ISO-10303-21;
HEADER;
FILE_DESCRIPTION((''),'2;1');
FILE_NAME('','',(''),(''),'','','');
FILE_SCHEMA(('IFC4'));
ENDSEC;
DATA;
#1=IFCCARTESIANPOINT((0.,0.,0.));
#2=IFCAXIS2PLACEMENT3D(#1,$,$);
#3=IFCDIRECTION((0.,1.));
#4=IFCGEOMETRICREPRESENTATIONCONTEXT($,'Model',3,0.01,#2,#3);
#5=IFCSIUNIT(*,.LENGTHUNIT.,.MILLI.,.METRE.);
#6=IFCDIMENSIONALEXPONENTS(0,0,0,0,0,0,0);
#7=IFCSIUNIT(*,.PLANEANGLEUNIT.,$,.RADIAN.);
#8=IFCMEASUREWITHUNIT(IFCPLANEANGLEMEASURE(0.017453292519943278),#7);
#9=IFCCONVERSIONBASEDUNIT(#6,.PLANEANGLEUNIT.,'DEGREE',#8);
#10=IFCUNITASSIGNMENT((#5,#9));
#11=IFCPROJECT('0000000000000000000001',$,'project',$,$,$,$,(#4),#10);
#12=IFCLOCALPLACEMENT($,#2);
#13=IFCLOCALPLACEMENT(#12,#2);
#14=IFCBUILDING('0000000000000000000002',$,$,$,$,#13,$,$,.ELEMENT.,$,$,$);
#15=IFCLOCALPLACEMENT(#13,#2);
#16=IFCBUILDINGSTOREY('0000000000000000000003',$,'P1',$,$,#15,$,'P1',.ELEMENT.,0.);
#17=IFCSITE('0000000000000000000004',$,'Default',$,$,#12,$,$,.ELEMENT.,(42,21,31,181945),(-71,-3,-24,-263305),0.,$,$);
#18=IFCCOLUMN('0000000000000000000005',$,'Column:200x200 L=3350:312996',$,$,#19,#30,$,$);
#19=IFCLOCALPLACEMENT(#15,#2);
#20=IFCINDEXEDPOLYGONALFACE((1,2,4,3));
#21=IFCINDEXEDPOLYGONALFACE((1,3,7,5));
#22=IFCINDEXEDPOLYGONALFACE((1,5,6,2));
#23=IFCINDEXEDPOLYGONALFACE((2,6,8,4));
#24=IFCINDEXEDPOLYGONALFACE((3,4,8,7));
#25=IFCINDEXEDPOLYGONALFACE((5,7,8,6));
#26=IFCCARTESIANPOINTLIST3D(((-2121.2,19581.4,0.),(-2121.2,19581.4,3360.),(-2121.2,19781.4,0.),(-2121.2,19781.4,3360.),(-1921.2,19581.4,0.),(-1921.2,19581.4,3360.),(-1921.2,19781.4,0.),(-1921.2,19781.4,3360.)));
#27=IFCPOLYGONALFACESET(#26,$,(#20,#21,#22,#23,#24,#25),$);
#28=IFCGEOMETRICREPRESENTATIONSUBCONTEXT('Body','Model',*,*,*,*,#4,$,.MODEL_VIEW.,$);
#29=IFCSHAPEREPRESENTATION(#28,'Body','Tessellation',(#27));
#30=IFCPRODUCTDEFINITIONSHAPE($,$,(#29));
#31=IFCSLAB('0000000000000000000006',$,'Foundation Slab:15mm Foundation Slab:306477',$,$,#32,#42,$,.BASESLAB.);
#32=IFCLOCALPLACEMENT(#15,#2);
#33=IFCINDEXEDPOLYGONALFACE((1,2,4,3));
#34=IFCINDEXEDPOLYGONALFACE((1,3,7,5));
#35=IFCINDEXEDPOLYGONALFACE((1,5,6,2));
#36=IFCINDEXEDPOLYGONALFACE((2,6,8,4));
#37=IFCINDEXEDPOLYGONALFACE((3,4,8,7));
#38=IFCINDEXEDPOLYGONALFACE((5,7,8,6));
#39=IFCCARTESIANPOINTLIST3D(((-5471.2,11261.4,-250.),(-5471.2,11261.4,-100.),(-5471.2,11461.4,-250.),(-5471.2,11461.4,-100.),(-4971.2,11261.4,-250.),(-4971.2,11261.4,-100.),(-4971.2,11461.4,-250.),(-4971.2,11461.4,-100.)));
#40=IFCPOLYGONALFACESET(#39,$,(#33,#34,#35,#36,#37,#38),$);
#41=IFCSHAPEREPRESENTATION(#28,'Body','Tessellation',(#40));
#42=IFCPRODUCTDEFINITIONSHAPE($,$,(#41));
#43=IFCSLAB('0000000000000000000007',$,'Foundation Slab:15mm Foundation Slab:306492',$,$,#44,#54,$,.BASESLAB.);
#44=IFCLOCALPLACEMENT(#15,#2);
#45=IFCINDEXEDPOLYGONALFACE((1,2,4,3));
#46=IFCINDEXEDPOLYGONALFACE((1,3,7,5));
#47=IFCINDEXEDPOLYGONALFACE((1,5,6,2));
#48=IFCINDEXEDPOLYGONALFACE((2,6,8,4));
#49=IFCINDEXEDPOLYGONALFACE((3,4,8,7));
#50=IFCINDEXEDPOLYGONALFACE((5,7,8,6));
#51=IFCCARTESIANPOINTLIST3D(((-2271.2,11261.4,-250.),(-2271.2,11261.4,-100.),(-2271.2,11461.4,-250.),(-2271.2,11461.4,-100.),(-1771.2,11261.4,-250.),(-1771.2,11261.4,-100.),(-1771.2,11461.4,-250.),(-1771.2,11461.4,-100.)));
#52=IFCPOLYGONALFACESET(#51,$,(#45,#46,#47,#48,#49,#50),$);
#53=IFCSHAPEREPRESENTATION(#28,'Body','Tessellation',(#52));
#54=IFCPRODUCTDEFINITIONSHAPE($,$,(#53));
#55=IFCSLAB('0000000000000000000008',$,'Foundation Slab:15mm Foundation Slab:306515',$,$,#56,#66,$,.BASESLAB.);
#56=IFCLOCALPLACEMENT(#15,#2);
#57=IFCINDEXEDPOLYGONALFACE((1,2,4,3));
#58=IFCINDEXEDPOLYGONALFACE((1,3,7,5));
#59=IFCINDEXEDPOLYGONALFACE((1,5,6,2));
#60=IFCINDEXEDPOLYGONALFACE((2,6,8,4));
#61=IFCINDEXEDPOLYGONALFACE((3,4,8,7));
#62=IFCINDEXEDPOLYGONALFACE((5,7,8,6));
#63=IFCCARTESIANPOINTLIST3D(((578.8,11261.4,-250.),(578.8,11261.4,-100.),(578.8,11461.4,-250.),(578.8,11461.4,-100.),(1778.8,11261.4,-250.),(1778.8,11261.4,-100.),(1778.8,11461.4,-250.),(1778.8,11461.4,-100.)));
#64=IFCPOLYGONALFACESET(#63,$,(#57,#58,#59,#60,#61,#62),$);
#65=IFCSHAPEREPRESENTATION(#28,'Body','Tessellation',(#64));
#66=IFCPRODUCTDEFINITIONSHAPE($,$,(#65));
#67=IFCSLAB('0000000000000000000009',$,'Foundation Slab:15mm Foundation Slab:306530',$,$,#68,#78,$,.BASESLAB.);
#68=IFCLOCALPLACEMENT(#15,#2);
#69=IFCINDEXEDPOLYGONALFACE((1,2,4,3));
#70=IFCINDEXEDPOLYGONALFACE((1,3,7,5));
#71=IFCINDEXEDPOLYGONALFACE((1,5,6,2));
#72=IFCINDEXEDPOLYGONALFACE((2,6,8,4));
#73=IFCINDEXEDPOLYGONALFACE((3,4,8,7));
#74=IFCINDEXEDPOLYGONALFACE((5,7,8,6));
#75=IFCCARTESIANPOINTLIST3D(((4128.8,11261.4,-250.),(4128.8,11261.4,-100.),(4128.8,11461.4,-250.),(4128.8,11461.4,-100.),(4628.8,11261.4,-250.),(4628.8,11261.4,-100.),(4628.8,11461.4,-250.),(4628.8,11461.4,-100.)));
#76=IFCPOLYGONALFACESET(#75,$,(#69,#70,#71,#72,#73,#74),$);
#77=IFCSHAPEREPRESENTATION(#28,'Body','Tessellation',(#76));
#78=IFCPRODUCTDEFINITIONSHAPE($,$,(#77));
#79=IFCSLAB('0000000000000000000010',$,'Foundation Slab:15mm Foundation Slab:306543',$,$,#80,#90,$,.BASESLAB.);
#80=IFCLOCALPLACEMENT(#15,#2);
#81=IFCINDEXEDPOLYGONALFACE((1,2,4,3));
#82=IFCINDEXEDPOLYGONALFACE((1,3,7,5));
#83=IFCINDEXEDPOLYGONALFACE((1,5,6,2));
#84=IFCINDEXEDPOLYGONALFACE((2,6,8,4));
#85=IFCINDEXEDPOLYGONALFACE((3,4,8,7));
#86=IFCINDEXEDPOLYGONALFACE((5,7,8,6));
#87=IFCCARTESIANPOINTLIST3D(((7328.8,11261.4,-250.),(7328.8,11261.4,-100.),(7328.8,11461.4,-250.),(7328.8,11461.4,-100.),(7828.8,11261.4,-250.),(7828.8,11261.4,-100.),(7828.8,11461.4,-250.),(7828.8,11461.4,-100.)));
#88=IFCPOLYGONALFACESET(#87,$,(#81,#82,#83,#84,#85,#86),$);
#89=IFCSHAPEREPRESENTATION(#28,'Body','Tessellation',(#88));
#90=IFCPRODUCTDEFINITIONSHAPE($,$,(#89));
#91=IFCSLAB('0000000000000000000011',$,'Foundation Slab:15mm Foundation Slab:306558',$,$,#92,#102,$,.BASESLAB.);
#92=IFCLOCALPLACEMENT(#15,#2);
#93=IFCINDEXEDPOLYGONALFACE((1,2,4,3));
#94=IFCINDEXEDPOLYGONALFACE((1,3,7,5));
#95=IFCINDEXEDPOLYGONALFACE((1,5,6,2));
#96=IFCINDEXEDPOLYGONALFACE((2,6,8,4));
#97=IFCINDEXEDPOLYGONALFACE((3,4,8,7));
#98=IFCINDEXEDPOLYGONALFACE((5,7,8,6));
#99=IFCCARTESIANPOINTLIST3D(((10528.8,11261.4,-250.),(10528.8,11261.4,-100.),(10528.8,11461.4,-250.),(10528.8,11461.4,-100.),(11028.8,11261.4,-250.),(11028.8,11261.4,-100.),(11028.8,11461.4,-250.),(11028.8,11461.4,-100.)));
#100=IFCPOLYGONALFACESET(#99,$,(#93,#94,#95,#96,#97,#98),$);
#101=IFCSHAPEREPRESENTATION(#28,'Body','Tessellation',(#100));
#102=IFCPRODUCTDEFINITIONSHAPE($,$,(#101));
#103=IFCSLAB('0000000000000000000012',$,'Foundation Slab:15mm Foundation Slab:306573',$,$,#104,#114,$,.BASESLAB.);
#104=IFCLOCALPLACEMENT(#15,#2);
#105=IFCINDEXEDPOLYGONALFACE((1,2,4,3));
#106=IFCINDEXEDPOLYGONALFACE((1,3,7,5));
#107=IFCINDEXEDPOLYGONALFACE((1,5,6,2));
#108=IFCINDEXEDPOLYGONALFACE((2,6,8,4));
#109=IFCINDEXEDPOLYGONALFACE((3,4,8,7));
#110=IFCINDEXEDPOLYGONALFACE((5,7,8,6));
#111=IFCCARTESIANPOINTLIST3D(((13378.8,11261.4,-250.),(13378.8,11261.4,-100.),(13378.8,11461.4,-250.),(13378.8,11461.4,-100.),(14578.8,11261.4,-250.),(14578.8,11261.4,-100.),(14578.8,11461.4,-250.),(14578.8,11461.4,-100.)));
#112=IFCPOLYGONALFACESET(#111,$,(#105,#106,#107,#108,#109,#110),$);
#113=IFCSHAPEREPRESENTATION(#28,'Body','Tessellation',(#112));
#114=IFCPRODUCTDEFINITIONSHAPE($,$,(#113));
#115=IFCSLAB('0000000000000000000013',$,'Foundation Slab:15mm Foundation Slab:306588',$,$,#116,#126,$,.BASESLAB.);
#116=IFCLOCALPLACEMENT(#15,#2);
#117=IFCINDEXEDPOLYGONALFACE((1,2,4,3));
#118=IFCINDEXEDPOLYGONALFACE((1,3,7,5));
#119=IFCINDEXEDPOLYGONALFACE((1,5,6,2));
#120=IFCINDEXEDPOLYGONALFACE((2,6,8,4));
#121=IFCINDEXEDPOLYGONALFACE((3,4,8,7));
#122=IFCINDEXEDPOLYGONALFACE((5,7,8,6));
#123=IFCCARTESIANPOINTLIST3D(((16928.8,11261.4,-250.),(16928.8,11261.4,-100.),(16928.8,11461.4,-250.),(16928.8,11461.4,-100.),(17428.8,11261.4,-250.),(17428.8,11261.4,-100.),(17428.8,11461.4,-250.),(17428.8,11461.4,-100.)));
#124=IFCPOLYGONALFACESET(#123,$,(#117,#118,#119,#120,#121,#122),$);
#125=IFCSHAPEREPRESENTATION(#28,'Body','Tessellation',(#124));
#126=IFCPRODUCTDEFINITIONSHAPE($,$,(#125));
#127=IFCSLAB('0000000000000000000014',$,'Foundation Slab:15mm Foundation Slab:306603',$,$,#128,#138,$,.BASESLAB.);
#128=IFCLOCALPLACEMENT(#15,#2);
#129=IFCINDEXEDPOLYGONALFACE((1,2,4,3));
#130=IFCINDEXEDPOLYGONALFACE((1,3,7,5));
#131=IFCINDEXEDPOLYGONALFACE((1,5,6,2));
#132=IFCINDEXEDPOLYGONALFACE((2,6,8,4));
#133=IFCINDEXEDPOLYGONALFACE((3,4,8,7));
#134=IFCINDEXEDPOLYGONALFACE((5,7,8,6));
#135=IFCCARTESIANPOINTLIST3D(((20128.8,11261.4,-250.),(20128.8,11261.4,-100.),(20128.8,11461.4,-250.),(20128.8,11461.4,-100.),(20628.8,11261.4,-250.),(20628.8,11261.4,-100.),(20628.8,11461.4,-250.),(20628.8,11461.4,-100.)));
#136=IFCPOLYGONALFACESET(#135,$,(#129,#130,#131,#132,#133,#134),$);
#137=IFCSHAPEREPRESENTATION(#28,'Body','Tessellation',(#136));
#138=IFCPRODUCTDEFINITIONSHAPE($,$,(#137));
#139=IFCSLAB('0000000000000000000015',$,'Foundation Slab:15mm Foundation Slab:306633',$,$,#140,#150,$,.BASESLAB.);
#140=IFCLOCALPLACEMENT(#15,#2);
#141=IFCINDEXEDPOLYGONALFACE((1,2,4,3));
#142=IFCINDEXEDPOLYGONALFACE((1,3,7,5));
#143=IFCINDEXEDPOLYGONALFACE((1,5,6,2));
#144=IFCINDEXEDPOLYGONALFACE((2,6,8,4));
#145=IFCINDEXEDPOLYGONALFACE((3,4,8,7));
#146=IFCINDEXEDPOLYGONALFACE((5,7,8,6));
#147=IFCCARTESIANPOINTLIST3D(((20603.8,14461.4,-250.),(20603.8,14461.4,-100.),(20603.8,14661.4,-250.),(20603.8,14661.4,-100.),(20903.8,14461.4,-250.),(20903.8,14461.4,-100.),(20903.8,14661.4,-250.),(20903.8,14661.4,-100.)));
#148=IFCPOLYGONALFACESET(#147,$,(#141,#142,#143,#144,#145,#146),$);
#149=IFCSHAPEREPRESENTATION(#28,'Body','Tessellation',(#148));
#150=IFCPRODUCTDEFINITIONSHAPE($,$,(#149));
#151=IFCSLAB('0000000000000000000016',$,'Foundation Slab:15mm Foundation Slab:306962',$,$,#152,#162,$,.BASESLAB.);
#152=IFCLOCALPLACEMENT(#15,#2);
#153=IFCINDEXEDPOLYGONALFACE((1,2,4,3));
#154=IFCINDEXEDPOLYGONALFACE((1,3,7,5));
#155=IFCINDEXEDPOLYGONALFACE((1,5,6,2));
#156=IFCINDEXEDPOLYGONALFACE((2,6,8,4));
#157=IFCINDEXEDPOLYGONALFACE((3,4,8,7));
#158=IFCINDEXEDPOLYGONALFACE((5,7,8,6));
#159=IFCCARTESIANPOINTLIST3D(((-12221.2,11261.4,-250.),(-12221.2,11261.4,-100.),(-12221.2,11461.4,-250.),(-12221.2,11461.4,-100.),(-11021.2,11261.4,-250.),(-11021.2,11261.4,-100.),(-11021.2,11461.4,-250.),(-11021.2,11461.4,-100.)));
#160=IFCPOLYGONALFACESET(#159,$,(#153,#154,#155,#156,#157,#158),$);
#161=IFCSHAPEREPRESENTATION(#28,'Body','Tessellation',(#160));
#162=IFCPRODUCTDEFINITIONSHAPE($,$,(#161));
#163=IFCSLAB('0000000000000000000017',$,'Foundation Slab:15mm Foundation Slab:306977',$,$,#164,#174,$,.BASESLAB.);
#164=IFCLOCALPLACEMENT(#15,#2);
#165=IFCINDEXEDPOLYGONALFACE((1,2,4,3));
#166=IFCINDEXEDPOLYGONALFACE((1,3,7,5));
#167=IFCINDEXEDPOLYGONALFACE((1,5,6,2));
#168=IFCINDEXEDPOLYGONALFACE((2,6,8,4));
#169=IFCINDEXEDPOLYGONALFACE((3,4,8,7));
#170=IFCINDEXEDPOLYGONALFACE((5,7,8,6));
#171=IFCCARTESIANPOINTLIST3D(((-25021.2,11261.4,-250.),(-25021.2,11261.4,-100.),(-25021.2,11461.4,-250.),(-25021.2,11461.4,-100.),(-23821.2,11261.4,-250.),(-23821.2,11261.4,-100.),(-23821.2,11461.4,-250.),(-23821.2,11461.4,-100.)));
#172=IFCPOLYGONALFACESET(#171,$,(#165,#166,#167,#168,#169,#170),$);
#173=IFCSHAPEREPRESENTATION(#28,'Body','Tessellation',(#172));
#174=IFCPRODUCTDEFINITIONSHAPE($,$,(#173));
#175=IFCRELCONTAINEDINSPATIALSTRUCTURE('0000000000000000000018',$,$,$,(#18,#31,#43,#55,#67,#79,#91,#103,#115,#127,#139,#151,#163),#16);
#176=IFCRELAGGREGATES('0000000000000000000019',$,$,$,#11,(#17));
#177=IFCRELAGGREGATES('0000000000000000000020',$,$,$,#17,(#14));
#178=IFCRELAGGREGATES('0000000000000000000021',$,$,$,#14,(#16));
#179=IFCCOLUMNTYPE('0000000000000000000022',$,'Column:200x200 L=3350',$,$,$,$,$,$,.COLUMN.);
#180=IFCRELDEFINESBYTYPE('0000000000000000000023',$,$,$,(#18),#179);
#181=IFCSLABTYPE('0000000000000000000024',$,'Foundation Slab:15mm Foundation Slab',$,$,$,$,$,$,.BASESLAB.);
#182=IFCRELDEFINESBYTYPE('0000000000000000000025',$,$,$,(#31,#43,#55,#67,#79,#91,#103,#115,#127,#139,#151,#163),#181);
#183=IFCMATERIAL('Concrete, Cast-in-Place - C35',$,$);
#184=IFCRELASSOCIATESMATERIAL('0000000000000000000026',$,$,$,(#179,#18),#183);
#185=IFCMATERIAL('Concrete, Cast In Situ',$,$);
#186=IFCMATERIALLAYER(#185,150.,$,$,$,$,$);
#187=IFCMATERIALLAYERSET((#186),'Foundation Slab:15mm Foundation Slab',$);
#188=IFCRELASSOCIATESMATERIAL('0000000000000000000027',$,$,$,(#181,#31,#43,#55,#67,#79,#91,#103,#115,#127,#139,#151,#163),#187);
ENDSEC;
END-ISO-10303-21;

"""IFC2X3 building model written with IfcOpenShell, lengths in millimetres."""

from ifc_helpers import new_model, entity, si_unit, converted_unit, direction, frame, frame_2d, origin, place, context, subcontext, project, spatial, rectangle, extrude, source, transform, mapped, material, layer, layer_set, layer_usage, type_object, type_shapes, element, save


model = new_model("IFC2X3")

# Units and contexts
model_context = context("Model", 3, precision=0.01, world=origin(), true_north=direction((0.0, 1.0)))
body_context = subcontext(model_context, "Body", "Model", "MODEL_VIEW")
ifc_project = project(units=[si_unit("LENGTHUNIT", "METRE", prefix="MILLI"), converted_unit("PLANEANGLEUNIT", "DEGREE", entity("IfcPlaneAngleMeasure", 0.017453292519943278), si_unit("PLANEANGLEUNIT", "RADIAN"), dimensions=[0, 0, 0, 0, 0, 0, 0])], contexts=[model_context])

# Site, building, storey
site_placement = place(None, origin())
site = spatial("IfcSite", under=ifc_project, at=site_placement, Name="Default", CompositionType="ELEMENT", RefLatitude=(42, 21, 31, 181945), RefLongitude=(-71, -3, -24, -263305), RefElevation=0.0)
building_placement = place(site_placement, origin())
building = spatial("IfcBuilding", under=site, at=building_placement, CompositionType="ELEMENT")
storey_placement = place(building_placement, origin())
storey = spatial("IfcBuildingStorey", under=building, at=storey_placement, Name="P1", LongName="P1", CompositionType="ELEMENT", Elevation=0.0)

# Column
ifc_material_1 = material(Name="Concrete, Cast-in-Place - C35")
column_type_1 = type_object("IfcColumnType", Name="Column:200x200 L=3350", PredefinedType="COLUMN", material=ifc_material_1)
shared_shape_1 = source(origin(), body_context, "Body", "SweptSolid", [
    extrude(rectangle(XDim=200.0, YDim=200.0, at=frame_2d((0.0, 0.0), x_axis=(1.0, 0.0))), frame((0.0, 0.0, 0.0), z_axis=(0.0, 0.0, 1.0), x_axis=(-1.0, 0.0, 0.0)), (0.0, 0.0, 1.0), 3360.0),
])
type_shapes(column_type_1, [shared_shape_1])
column_1_placement = place(storey_placement, frame((-2021.2, 19681.4, 0.0)))
element("IfcColumn", 1, at=column_1_placement, inside=storey, type_object=column_type_1, material=ifc_material_1, Name="Column:200x200 L=3350:312996", context=body_context, shape_type="MappedRepresentation", body=[
    mapped(shared_shape_1, transform((0.0, 0.0, 0.0), scale=1.0)),
])

# Slabs
ifc_material_2 = material(Name="Concrete, Cast In Situ")
ifc_layer_1 = layer(ifc_material_2, 150.0)
ifc_layer_set_1 = layer_set([ifc_layer_1], Name="Foundation Slab:15mm Foundation Slab")
ifc_layer_usage_1 = layer_usage(ifc_layer_set_1, "AXIS3", "POSITIVE", 0.0)
slab_type = type_object("IfcSlabType", Name="Foundation Slab:15mm Foundation Slab", PredefinedType="BASESLAB", material=ifc_layer_set_1)
slab_1_placement = place(storey_placement, origin())
element("IfcSlab", 2, at=slab_1_placement, inside=storey, type_object=slab_type, material=ifc_layer_usage_1, Name="Foundation Slab:15mm Foundation Slab:306477", PredefinedType="BASESLAB", context=body_context, shape_type="SweptSolid", body=[
    extrude(rectangle(XDim=200.0, YDim=500.0, at=frame_2d((0.0, 0.0), x_axis=(1.0, 0.0))), frame((-5221.2, 11361.4, -100.0), z_axis=(0.0, 0.0, -1.0), x_axis=(0.0, 1.0, 0.0)), (0.0, 0.0, 1.0), 150.0),
])
ifc_layer_usage_2 = layer_usage(ifc_layer_set_1, "AXIS3", "POSITIVE", 0.0)
slab_2_placement = place(storey_placement, origin())
element("IfcSlab", 3, at=slab_2_placement, inside=storey, type_object=slab_type, material=ifc_layer_usage_2, Name="Foundation Slab:15mm Foundation Slab:306492", PredefinedType="BASESLAB", context=body_context, shape_type="SweptSolid", body=[
    extrude(rectangle(XDim=200.0, YDim=500.0, at=frame_2d((0.0, 0.0), x_axis=(1.0, 0.0))), frame((-2021.2, 11361.4, -100.0), z_axis=(0.0, 0.0, -1.0), x_axis=(0.0, 1.0, 0.0)), (0.0, 0.0, 1.0), 150.0),
])
ifc_layer_usage_3 = layer_usage(ifc_layer_set_1, "AXIS3", "POSITIVE", 0.0)
slab_3_placement = place(storey_placement, origin())
element("IfcSlab", 4, at=slab_3_placement, inside=storey, type_object=slab_type, material=ifc_layer_usage_3, Name="Foundation Slab:15mm Foundation Slab:306515", PredefinedType="BASESLAB", context=body_context, shape_type="SweptSolid", body=[
    extrude(rectangle(XDim=200.0, YDim=1200.0, at=frame_2d((0.0, 0.0), x_axis=(1.0, 0.0))), frame((1178.8, 11361.4, -100.0), z_axis=(0.0, 0.0, -1.0), x_axis=(0.0, 1.0, 0.0)), (0.0, 0.0, 1.0), 150.0),
])
ifc_layer_usage_4 = layer_usage(ifc_layer_set_1, "AXIS3", "POSITIVE", 0.0)
slab_4_placement = place(storey_placement, origin())
element("IfcSlab", 5, at=slab_4_placement, inside=storey, type_object=slab_type, material=ifc_layer_usage_4, Name="Foundation Slab:15mm Foundation Slab:306530", PredefinedType="BASESLAB", context=body_context, shape_type="SweptSolid", body=[
    extrude(rectangle(XDim=200.0, YDim=500.0, at=frame_2d((0.0, 0.0), x_axis=(1.0, 0.0))), frame((4378.8, 11361.4, -100.0), z_axis=(0.0, 0.0, -1.0), x_axis=(0.0, 1.0, 0.0)), (0.0, 0.0, 1.0), 150.0),
])
ifc_layer_usage_5 = layer_usage(ifc_layer_set_1, "AXIS3", "POSITIVE", 0.0)
slab_5_placement = place(storey_placement, origin())
element("IfcSlab", 6, at=slab_5_placement, inside=storey, type_object=slab_type, material=ifc_layer_usage_5, Name="Foundation Slab:15mm Foundation Slab:306543", PredefinedType="BASESLAB", context=body_context, shape_type="SweptSolid", body=[
    extrude(rectangle(XDim=200.0, YDim=500.0, at=frame_2d((0.0, 0.0), x_axis=(1.0, 0.0))), frame((7578.8, 11361.4, -100.0), z_axis=(0.0, 0.0, -1.0), x_axis=(0.0, 1.0, 0.0)), (0.0, 0.0, 1.0), 150.0),
])
ifc_layer_usage_6 = layer_usage(ifc_layer_set_1, "AXIS3", "POSITIVE", 0.0)
slab_6_placement = place(storey_placement, origin())
element("IfcSlab", 7, at=slab_6_placement, inside=storey, type_object=slab_type, material=ifc_layer_usage_6, Name="Foundation Slab:15mm Foundation Slab:306558", PredefinedType="BASESLAB", context=body_context, shape_type="SweptSolid", body=[
    extrude(rectangle(XDim=200.0, YDim=500.0, at=frame_2d((0.0, 0.0), x_axis=(1.0, 0.0))), frame((10778.8, 11361.4, -100.0), z_axis=(0.0, 0.0, -1.0), x_axis=(0.0, 1.0, 0.0)), (0.0, 0.0, 1.0), 150.0),
])
ifc_layer_usage_7 = layer_usage(ifc_layer_set_1, "AXIS3", "POSITIVE", 0.0)
slab_7_placement = place(storey_placement, origin())
element("IfcSlab", 8, at=slab_7_placement, inside=storey, type_object=slab_type, material=ifc_layer_usage_7, Name="Foundation Slab:15mm Foundation Slab:306573", PredefinedType="BASESLAB", context=body_context, shape_type="SweptSolid", body=[
    extrude(rectangle(XDim=200.0, YDim=1200.0, at=frame_2d((0.0, 0.0), x_axis=(1.0, 0.0))), frame((13978.8, 11361.4, -100.0), z_axis=(0.0, 0.0, -1.0), x_axis=(0.0, 1.0, 0.0)), (0.0, 0.0, 1.0), 150.0),
])
ifc_layer_usage_8 = layer_usage(ifc_layer_set_1, "AXIS3", "POSITIVE", 0.0)
slab_8_placement = place(storey_placement, origin())
element("IfcSlab", 9, at=slab_8_placement, inside=storey, type_object=slab_type, material=ifc_layer_usage_8, Name="Foundation Slab:15mm Foundation Slab:306588", PredefinedType="BASESLAB", context=body_context, shape_type="SweptSolid", body=[
    extrude(rectangle(XDim=200.0, YDim=500.0, at=frame_2d((0.0, 0.0), x_axis=(1.0, 0.0))), frame((17178.8, 11361.4, -100.0), z_axis=(0.0, 0.0, -1.0), x_axis=(0.0, 1.0, 0.0)), (0.0, 0.0, 1.0), 150.0),
])
ifc_layer_usage_9 = layer_usage(ifc_layer_set_1, "AXIS3", "POSITIVE", 0.0)
slab_9_placement = place(storey_placement, origin())
element("IfcSlab", 10, at=slab_9_placement, inside=storey, type_object=slab_type, material=ifc_layer_usage_9, Name="Foundation Slab:15mm Foundation Slab:306603", PredefinedType="BASESLAB", context=body_context, shape_type="SweptSolid", body=[
    extrude(rectangle(XDim=200.0, YDim=500.0, at=frame_2d((0.0, 0.0), x_axis=(1.0, 0.0))), frame((20378.8, 11361.4, -100.0), z_axis=(0.0, 0.0, -1.0), x_axis=(0.0, 1.0, 0.0)), (0.0, 0.0, 1.0), 150.0),
])
ifc_layer_usage_10 = layer_usage(ifc_layer_set_1, "AXIS3", "POSITIVE", 0.0)
slab_10_placement = place(storey_placement, origin())
element("IfcSlab", 11, at=slab_10_placement, inside=storey, type_object=slab_type, material=ifc_layer_usage_10, Name="Foundation Slab:15mm Foundation Slab:306633", PredefinedType="BASESLAB", context=body_context, shape_type="SweptSolid", body=[
    extrude(rectangle(XDim=200.0, YDim=300.0, at=frame_2d((0.0, 0.0), x_axis=(1.0, 0.0))), frame((20753.8, 14561.4, -100.0), z_axis=(0.0, 0.0, -1.0), x_axis=(0.0, 1.0, 0.0)), (0.0, 0.0, 1.0), 150.0),
])
ifc_layer_usage_11 = layer_usage(ifc_layer_set_1, "AXIS3", "POSITIVE", 0.0)
slab_11_placement = place(storey_placement, origin())
element("IfcSlab", 12, at=slab_11_placement, inside=storey, type_object=slab_type, material=ifc_layer_usage_11, Name="Foundation Slab:15mm Foundation Slab:306962", PredefinedType="BASESLAB", context=body_context, shape_type="SweptSolid", body=[
    extrude(rectangle(XDim=200.0, YDim=1200.0, at=frame_2d((0.0, 0.0), x_axis=(1.0, 0.0))), frame((-11621.2, 11361.4, -100.0), z_axis=(0.0, 0.0, -1.0), x_axis=(0.0, 1.0, 0.0)), (0.0, 0.0, 1.0), 150.0),
])
ifc_layer_usage_12 = layer_usage(ifc_layer_set_1, "AXIS3", "POSITIVE", 0.0)
slab_12_placement = place(storey_placement, origin())
element("IfcSlab", 13, at=slab_12_placement, inside=storey, type_object=slab_type, material=ifc_layer_usage_12, Name="Foundation Slab:15mm Foundation Slab:306977", PredefinedType="BASESLAB", context=body_context, shape_type="SweptSolid", body=[
    extrude(rectangle(XDim=200.0, YDim=1200.0, at=frame_2d((0.0, 0.0), x_axis=(1.0, 0.0))), frame((-24421.2, 11361.4, -100.0), z_axis=(0.0, 0.0, -1.0), x_axis=(0.0, 1.0, 0.0)), (0.0, 0.0, 1.0), 150.0),
])

save(model, "model.ifc")
